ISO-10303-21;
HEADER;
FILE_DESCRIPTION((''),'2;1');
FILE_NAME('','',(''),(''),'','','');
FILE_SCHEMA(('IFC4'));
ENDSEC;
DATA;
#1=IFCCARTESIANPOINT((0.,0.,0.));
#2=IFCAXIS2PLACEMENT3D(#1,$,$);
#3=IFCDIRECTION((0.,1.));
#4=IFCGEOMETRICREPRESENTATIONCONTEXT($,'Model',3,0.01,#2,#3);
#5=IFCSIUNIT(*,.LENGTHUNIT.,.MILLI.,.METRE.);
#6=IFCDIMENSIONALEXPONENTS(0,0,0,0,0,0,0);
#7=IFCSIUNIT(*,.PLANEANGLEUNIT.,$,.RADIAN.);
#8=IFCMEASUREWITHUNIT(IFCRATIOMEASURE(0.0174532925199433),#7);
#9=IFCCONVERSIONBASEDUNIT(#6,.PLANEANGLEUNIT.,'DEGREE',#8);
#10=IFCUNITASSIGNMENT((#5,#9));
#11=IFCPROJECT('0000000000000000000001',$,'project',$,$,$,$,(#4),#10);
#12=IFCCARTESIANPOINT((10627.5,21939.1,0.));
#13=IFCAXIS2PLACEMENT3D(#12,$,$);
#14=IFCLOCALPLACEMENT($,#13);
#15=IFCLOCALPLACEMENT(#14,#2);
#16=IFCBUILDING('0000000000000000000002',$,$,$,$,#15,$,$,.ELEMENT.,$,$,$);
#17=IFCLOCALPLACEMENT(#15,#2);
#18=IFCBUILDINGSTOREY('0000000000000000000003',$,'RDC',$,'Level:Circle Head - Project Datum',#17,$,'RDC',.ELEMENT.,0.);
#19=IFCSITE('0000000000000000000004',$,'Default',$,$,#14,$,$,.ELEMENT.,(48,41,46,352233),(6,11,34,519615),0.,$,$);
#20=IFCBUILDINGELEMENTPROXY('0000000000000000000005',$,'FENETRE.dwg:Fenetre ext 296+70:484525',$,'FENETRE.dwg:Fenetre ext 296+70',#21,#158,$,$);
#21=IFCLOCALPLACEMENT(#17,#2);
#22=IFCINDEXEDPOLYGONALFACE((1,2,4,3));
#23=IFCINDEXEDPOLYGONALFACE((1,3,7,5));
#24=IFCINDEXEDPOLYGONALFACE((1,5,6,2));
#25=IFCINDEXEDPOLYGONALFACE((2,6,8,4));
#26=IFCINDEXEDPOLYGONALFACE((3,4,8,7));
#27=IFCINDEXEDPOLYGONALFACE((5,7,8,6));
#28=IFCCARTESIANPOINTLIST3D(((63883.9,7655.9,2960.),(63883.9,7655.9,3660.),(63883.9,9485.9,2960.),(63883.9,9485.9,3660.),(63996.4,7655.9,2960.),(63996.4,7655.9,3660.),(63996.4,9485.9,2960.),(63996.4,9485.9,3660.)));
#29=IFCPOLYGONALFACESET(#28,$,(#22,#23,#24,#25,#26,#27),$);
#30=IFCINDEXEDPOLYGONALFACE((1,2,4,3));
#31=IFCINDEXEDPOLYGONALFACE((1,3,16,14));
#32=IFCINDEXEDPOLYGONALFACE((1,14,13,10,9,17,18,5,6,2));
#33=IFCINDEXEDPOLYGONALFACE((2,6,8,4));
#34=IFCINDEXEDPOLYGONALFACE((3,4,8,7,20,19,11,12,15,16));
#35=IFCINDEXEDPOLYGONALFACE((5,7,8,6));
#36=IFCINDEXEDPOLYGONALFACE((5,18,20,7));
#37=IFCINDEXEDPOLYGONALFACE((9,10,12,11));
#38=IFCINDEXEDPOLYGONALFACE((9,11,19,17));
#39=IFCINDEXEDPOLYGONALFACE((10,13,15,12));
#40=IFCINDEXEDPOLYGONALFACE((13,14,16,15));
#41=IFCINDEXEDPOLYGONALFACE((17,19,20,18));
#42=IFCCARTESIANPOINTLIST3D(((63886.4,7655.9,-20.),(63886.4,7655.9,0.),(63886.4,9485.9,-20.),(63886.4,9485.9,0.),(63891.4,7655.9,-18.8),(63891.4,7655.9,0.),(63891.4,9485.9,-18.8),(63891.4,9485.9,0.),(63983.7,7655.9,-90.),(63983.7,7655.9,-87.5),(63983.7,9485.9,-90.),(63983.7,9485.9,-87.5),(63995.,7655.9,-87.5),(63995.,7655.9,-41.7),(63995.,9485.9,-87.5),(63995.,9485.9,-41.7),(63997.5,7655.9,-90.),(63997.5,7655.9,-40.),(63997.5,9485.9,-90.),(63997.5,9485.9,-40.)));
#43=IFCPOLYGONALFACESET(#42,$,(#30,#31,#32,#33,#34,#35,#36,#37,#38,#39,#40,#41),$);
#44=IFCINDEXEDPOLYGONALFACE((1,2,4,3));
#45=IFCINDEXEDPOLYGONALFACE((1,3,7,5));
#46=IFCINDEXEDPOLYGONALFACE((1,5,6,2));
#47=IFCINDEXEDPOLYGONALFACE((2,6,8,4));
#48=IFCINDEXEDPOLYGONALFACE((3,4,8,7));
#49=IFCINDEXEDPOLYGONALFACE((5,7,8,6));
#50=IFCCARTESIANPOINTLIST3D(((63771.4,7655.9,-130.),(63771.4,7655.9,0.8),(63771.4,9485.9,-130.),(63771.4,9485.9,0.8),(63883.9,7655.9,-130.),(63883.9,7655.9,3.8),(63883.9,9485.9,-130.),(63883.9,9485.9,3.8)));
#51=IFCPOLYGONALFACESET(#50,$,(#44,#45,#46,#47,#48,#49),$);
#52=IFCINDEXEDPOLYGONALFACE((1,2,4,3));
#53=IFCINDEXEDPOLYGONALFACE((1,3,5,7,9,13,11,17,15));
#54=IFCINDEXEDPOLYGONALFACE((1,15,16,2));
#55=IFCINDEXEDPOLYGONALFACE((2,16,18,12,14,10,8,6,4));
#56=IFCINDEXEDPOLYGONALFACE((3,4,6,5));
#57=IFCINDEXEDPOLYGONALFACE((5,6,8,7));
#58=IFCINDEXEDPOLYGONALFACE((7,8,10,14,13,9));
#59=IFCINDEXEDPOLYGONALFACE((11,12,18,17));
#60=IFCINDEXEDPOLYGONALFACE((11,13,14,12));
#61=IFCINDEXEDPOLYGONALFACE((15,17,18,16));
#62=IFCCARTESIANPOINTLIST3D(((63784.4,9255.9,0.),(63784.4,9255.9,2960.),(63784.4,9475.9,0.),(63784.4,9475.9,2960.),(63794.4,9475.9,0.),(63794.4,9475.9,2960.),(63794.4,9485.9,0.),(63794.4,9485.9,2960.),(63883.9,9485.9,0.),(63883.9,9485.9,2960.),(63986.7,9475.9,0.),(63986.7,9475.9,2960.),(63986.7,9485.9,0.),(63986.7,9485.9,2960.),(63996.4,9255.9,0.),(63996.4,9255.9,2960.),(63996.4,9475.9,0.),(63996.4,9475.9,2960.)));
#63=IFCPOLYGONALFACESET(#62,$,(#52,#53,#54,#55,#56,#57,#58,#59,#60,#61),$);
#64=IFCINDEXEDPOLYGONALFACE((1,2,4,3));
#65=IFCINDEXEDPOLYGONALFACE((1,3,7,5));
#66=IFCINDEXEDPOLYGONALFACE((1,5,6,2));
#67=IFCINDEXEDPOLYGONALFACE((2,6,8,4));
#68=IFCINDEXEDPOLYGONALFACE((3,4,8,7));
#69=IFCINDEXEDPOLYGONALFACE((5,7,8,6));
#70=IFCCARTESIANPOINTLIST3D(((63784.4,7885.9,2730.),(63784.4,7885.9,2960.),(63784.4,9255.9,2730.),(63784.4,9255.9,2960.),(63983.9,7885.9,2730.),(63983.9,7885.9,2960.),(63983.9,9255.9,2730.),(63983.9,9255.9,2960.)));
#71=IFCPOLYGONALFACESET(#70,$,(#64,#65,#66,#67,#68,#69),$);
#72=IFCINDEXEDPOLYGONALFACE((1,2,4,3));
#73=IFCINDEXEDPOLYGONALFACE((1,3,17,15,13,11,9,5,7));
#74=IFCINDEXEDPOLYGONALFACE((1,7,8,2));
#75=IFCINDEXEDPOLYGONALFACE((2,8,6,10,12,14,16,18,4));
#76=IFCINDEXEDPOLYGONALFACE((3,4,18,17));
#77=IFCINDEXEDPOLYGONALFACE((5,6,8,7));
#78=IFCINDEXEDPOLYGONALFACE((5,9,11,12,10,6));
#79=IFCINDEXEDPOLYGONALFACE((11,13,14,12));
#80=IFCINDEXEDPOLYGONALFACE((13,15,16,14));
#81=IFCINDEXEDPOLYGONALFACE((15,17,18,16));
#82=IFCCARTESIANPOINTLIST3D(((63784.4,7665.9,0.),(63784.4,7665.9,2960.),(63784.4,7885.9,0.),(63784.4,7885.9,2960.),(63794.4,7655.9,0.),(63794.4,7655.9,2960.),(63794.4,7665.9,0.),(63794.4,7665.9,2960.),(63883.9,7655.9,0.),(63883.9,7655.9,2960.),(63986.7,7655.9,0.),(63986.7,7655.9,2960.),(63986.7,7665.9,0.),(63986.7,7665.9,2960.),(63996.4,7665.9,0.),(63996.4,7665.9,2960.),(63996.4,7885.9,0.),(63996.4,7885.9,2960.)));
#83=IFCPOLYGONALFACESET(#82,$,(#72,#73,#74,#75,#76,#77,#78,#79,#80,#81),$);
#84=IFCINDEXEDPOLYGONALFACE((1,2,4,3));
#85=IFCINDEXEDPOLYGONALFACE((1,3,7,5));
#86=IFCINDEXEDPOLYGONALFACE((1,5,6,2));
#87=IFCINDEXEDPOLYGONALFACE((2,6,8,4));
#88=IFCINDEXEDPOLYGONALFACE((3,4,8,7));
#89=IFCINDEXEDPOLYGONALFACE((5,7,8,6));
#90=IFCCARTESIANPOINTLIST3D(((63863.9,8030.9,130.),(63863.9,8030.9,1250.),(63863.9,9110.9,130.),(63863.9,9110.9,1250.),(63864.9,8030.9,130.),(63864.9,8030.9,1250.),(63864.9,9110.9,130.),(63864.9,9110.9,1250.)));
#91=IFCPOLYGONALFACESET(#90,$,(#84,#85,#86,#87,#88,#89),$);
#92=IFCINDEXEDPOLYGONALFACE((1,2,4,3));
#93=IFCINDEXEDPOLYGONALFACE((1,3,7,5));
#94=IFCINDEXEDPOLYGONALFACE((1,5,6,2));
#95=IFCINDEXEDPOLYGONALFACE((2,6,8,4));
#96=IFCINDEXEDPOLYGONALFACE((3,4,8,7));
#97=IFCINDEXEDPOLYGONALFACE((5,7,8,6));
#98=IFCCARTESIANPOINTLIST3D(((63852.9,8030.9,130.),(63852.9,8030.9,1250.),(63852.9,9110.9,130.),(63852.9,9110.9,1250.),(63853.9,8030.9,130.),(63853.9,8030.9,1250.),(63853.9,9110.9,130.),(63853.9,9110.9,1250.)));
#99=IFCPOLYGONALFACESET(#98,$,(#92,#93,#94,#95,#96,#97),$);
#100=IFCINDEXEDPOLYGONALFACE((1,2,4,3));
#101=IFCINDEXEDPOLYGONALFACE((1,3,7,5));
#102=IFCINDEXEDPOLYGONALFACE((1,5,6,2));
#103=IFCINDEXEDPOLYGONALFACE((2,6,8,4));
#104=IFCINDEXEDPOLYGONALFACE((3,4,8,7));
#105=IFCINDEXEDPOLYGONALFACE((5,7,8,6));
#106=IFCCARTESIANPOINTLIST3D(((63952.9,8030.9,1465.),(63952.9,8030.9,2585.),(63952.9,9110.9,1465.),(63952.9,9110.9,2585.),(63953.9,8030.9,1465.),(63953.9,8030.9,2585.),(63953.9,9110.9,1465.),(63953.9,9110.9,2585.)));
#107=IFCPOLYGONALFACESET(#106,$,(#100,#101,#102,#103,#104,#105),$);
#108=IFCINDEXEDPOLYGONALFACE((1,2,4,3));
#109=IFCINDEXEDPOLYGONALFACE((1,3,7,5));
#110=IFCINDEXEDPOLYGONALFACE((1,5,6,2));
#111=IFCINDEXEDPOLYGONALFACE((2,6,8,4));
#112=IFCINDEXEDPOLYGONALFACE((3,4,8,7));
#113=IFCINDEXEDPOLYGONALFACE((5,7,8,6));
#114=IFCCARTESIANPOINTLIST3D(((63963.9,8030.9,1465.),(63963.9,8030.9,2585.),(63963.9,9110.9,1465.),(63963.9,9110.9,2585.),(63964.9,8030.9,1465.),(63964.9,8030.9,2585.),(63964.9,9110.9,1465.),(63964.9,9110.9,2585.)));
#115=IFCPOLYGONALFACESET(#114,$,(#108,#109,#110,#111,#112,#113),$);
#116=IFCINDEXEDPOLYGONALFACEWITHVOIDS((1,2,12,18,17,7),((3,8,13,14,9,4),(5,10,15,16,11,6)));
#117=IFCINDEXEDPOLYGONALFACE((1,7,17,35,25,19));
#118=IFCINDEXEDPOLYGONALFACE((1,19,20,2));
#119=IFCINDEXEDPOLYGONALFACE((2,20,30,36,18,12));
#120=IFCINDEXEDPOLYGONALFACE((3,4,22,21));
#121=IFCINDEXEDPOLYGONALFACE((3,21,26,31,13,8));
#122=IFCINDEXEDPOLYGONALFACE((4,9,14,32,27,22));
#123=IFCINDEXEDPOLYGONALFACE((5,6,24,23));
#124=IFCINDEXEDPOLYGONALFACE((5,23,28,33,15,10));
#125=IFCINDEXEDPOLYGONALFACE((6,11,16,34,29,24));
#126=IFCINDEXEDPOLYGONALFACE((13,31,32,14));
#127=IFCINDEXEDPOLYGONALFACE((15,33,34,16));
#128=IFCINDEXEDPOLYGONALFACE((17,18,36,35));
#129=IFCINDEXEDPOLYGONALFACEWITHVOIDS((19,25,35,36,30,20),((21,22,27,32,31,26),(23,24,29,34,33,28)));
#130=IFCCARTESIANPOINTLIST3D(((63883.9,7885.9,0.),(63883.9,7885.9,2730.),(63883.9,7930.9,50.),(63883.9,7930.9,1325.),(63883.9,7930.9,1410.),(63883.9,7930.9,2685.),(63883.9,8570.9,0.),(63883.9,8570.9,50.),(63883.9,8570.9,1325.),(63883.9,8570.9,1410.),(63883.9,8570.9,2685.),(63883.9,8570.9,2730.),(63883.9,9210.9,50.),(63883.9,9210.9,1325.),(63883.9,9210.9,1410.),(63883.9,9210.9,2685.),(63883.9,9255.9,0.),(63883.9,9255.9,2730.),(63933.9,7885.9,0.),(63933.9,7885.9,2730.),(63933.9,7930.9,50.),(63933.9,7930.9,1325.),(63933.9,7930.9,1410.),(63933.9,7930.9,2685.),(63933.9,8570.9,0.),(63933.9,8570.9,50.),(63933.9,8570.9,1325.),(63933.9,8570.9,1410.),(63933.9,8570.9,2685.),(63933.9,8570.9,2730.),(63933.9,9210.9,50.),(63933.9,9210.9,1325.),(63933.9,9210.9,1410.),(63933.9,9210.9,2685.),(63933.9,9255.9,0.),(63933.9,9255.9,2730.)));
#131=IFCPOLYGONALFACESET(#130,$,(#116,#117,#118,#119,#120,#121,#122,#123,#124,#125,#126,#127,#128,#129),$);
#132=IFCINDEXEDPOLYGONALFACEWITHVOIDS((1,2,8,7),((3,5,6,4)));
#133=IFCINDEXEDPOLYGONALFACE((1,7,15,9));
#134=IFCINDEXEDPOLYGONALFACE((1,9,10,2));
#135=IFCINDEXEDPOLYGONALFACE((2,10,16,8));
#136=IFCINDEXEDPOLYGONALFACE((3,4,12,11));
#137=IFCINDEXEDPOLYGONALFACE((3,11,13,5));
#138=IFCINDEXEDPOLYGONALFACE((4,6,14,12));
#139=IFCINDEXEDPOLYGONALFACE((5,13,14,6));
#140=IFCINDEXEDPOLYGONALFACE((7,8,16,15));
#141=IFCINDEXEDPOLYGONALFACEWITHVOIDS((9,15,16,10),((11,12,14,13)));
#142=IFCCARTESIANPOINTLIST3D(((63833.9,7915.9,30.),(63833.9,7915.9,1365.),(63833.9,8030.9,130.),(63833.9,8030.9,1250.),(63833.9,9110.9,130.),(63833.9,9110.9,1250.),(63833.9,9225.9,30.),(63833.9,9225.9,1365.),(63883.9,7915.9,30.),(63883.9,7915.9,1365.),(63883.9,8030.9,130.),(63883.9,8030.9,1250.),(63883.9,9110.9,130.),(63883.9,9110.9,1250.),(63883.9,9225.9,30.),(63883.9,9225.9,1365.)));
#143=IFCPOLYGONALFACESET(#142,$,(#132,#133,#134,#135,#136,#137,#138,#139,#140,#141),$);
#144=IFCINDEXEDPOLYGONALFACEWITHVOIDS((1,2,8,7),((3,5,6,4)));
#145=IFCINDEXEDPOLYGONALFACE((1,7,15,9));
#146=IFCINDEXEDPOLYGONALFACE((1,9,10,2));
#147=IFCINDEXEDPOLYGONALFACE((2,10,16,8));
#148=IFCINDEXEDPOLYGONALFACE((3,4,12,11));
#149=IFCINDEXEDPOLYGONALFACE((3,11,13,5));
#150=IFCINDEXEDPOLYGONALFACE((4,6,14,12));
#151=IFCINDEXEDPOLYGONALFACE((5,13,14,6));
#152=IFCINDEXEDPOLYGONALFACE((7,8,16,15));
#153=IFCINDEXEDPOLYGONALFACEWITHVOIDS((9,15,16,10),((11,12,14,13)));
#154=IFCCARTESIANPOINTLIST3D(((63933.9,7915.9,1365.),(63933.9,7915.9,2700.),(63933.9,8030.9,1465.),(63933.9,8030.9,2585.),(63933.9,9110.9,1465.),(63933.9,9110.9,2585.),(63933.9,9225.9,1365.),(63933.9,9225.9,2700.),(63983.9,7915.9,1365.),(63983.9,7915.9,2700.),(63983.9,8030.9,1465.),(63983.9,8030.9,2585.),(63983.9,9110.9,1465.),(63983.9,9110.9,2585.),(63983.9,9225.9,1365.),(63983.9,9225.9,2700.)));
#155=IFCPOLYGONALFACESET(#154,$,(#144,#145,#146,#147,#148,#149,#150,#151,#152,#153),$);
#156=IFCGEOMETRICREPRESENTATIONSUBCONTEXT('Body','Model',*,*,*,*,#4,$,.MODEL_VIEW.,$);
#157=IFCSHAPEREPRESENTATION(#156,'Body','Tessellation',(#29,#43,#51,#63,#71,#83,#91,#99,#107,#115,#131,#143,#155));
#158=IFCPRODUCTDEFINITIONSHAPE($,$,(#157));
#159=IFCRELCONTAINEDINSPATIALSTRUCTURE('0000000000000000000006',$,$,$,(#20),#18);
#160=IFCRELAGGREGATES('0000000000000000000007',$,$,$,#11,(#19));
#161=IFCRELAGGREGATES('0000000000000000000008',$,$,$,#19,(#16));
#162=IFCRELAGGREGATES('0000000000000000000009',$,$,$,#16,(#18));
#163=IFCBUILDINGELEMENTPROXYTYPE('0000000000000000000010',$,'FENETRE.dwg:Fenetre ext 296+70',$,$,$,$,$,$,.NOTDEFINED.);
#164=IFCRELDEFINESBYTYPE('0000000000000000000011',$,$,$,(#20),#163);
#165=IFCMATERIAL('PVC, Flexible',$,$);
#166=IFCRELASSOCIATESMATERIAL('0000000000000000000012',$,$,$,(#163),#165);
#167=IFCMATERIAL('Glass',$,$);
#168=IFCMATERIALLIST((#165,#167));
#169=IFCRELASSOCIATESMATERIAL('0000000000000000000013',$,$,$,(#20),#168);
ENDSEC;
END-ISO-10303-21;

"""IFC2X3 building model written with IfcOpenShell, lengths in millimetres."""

from ifc_helpers import new_model, entity, si_unit, converted_unit, direction, frame, frame_2d, origin, origin_2d_with_axis, place, context, subcontext, project, spatial, polyline, rectangle, outline, extrude, source, transform, mapped, material, material_list, type_object, type_shapes, element, save


model = new_model("IFC2X3")

# Units and contexts
model_context = context("Model", 3, precision=0.01, world=origin(), true_north=direction((0.0, 1.0)))
body_context = subcontext(model_context, "Body", "Model", "MODEL_VIEW")
ifc_project = project(units=[si_unit("LENGTHUNIT", "METRE", prefix="MILLI"), converted_unit("PLANEANGLEUNIT", "DEGREE", entity("IfcRatioMeasure", 0.0174532925199433), si_unit("PLANEANGLEUNIT", "RADIAN"), dimensions=[0, 0, 0, 0, 0, 0, 0])], contexts=[model_context])

# Site, building, storey
site_placement = place(None, frame((10627.5, 21939.1, 0.0)))
site = spatial("IfcSite", under=ifc_project, at=site_placement, Name="Default", CompositionType="ELEMENT", RefLatitude=(48, 41, 46, 352233), RefLongitude=(6, 11, 34, 519615), RefElevation=0.0)
building_placement = place(site_placement, origin())
building = spatial("IfcBuilding", under=site, at=building_placement, CompositionType="ELEMENT")
storey_placement = place(building_placement, origin())
storey = spatial("IfcBuildingStorey", under=building, at=storey_placement, Name="RDC", ObjectType="Level:Circle Head - Project Datum", LongName="RDC", CompositionType="ELEMENT", Elevation=0.0)

# Building element proxy
ifc_material_1 = material(Name="PVC, Flexible")
ifc_material_2 = material(Name="Glass")
building_element_proxy_type_1 = type_object("IfcBuildingElementProxyType", Name="FENETRE.dwg:Fenetre ext 296+70", PredefinedType="NOTDEFINED", material=ifc_material_1)
shared_shape_1 = source(origin(), body_context, "Body", "SweptSolid", [
    extrude(rectangle(XDim=112.5, YDim=1830.0, at=origin_2d_with_axis()), frame((-10.4, -56.3, 2960.0), z_axis=(0.0, 0.0, 1.0), x_axis=(0.0, 1.0, 0.0)), (0.0, 0.0, 1.0), 700.0),
    extrude(outline(polyline([(27.5, -64.4), (47.5, -64.4), (47.5, -59.4), (28.8, -59.4), (7.5, 46.7), (-42.5, 46.7), (-42.5, 32.9), (-40.0, 32.9), (-40.0, 44.2), (5.8, 44.2), (27.5, -64.4)])), frame((-925.4, -66.9, -47.5), z_axis=(1.0, 0.0, 0.0), x_axis=(0.0, 0.0, 1.0)), (0.0, 0.0, 1.0), 1830.0),
    extrude(outline(polyline([(-54.5, -66.1), (58.0, -66.1), (54.5, 67.6), (-58.0, 64.6), (-54.5, -66.1)])), frame((-925.4, 56.3, -63.8), z_axis=(1.0, 0.0, 0.0), x_axis=(0.0, -0.999645, 0.02665)), (0.0, 0.0, 1.0), 1830.0),
    extrude(outline(polyline([(-97.0, -55.6), (5.9, -55.6), (95.4, -55.6), (95.4, -45.6), (105.4, -45.6), (105.4, 174.4), (-106.6, 174.4), (-106.6, -45.6), (-97.0, -45.6), (-97.0, -55.6)])), frame((849.0, -5.9, 0.0), z_axis=(0.0, 0.0, 1.0), x_axis=(0.0, 1.0, 0.0)), (0.0, 0.0, 1.0), 2960.0),
    extrude(rectangle(XDim=1370.0, YDim=199.5, at=origin_2d_with_axis()), frame((-10.4, -0.3, 2730.0), z_axis=(0.0, 0.0, 1.0), x_axis=(-1.0, 0.0, 0.0)), (0.0, 0.0, 1.0), 230.0),
    extrude(outline(polyline([(-55.6, 97.0), (-55.6, -5.9), (-55.6, -95.4), (-45.6, -95.4), (-45.6, -105.4), (174.4, -105.4), (174.4, 106.6), (-45.6, 106.6), (-45.6, 97.0), (-55.6, 97.0)])), frame((-869.9, -5.9, 0.0), z_axis=(0.0, 0.0, -1.0), x_axis=(1.0, 0.0, 0.0)), (0.0, 0.0, -1.0), 2960.0),
    extrude(rectangle(XDim=1080.0, YDim=1.0, at=origin_2d_with_axis()), frame((-10.4, 19.5, 130.0), z_axis=(0.0, 0.0, 1.0), x_axis=(-1.0, 0.0, 0.0)), (0.0, 0.0, 1.0), 1120.0),
    extrude(rectangle(XDim=1080.0, YDim=1.0, at=origin_2d_with_axis()), frame((-10.4, 30.5, 130.0), z_axis=(0.0, 0.0, 1.0), x_axis=(-1.0, 0.0, 0.0)), (0.0, 0.0, 1.0), 1120.0),
    extrude(rectangle(XDim=1080.0, YDim=1.0, at=frame_2d((0.0, 0.0), x_axis=(1.0, 0.0))), frame((-10.4, -69.5, 1465.0), z_axis=(0.0, 0.0, 1.0), x_axis=(-1.0, 0.0, 0.0)), (0.0, 0.0, 1.0), 1120.0),
    extrude(rectangle(XDim=1080.0, YDim=1.0, at=frame_2d((0.0, 0.0), x_axis=(1.0, 0.0))), frame((-10.4, -80.5, 1465.0), z_axis=(0.0, 0.0, 1.0), x_axis=(-1.0, 0.0, 0.0)), (0.0, 0.0, 1.0), 1120.0),
    extrude(outline(polyline([(-685.0, -1365.0), (0.0, -1365.0), (685.0, -1365.0), (685.0, 1365.0), (0.0, 1365.0), (-685.0, 1365.0), (-685.0, -1365.0)]), holes=[polyline([(-640.0, -1320.0), (-640.0, -45.0), (0.0, -45.0), (640.0, -45.0), (640.0, -1320.0), (0.0, -1320.0), (-640.0, -1320.0)]), polyline([(-640.0, 40.0), (-640.0, 1315.0), (0.0, 1315.0), (640.0, 1315.0), (640.0, 40.0), (0.0, 40.0), (-640.0, 40.0)])]), frame((-10.4, -50.0, 1365.0), z_axis=(0.0, 1.0, 0.0), x_axis=(1.0, 0.0, 0.0)), (0.0, 0.0, 1.0), 50.0),
    extrude(outline(polyline([(-655.0, -667.5), (655.0, -667.5), (655.0, 667.5), (-655.0, 667.5), (-655.0, -667.5)]), holes=[polyline([(-540.0, 552.5), (540.0, 552.5), (540.0, -567.5), (-540.0, -567.5), (-540.0, 552.5)])]), frame((-10.4, 0.0, 697.5), z_axis=(0.0, 1.0, 0.0), x_axis=(-1.0, 0.0, 0.0)), (0.0, 0.0, 1.0), 50.0),
    extrude(outline(polyline([(-655.0, -667.5), (655.0, -667.5), (655.0, 667.5), (-655.0, 667.5), (-655.0, -667.5)]), holes=[polyline([(-540.0, 552.5), (540.0, 552.5), (540.0, -567.5), (-540.0, -567.5), (-540.0, 552.5)])]), frame((-10.4, -100.0, 2032.5), z_axis=(0.0, 1.0, 0.0), x_axis=(-1.0, 0.0, 0.0)), (0.0, 0.0, 1.0), 50.0),
])
type_shapes(building_element_proxy_type_1, [shared_shape_1])
ifc_material_list_1 = material_list([ifc_material_1, ifc_material_2])
proxy_1_placement = place(storey_placement, frame((63883.9, 8581.3, 0.0), z_axis=(0.0, 0.0, 1.0), x_axis=(0.0, 1.0, 0.0)))
element("IfcBuildingElementProxy", 1, at=proxy_1_placement, inside=storey, type_object=building_element_proxy_type_1, material=ifc_material_list_1, Name="FENETRE.dwg:Fenetre ext 296+70:484525", ObjectType="FENETRE.dwg:Fenetre ext 296+70", context=body_context, shape_type="MappedRepresentation", body=[
    mapped(shared_shape_1, transform((0.0, 0.0, 0.0), scale=1.0)),
])

save(model, "model.ifc")
